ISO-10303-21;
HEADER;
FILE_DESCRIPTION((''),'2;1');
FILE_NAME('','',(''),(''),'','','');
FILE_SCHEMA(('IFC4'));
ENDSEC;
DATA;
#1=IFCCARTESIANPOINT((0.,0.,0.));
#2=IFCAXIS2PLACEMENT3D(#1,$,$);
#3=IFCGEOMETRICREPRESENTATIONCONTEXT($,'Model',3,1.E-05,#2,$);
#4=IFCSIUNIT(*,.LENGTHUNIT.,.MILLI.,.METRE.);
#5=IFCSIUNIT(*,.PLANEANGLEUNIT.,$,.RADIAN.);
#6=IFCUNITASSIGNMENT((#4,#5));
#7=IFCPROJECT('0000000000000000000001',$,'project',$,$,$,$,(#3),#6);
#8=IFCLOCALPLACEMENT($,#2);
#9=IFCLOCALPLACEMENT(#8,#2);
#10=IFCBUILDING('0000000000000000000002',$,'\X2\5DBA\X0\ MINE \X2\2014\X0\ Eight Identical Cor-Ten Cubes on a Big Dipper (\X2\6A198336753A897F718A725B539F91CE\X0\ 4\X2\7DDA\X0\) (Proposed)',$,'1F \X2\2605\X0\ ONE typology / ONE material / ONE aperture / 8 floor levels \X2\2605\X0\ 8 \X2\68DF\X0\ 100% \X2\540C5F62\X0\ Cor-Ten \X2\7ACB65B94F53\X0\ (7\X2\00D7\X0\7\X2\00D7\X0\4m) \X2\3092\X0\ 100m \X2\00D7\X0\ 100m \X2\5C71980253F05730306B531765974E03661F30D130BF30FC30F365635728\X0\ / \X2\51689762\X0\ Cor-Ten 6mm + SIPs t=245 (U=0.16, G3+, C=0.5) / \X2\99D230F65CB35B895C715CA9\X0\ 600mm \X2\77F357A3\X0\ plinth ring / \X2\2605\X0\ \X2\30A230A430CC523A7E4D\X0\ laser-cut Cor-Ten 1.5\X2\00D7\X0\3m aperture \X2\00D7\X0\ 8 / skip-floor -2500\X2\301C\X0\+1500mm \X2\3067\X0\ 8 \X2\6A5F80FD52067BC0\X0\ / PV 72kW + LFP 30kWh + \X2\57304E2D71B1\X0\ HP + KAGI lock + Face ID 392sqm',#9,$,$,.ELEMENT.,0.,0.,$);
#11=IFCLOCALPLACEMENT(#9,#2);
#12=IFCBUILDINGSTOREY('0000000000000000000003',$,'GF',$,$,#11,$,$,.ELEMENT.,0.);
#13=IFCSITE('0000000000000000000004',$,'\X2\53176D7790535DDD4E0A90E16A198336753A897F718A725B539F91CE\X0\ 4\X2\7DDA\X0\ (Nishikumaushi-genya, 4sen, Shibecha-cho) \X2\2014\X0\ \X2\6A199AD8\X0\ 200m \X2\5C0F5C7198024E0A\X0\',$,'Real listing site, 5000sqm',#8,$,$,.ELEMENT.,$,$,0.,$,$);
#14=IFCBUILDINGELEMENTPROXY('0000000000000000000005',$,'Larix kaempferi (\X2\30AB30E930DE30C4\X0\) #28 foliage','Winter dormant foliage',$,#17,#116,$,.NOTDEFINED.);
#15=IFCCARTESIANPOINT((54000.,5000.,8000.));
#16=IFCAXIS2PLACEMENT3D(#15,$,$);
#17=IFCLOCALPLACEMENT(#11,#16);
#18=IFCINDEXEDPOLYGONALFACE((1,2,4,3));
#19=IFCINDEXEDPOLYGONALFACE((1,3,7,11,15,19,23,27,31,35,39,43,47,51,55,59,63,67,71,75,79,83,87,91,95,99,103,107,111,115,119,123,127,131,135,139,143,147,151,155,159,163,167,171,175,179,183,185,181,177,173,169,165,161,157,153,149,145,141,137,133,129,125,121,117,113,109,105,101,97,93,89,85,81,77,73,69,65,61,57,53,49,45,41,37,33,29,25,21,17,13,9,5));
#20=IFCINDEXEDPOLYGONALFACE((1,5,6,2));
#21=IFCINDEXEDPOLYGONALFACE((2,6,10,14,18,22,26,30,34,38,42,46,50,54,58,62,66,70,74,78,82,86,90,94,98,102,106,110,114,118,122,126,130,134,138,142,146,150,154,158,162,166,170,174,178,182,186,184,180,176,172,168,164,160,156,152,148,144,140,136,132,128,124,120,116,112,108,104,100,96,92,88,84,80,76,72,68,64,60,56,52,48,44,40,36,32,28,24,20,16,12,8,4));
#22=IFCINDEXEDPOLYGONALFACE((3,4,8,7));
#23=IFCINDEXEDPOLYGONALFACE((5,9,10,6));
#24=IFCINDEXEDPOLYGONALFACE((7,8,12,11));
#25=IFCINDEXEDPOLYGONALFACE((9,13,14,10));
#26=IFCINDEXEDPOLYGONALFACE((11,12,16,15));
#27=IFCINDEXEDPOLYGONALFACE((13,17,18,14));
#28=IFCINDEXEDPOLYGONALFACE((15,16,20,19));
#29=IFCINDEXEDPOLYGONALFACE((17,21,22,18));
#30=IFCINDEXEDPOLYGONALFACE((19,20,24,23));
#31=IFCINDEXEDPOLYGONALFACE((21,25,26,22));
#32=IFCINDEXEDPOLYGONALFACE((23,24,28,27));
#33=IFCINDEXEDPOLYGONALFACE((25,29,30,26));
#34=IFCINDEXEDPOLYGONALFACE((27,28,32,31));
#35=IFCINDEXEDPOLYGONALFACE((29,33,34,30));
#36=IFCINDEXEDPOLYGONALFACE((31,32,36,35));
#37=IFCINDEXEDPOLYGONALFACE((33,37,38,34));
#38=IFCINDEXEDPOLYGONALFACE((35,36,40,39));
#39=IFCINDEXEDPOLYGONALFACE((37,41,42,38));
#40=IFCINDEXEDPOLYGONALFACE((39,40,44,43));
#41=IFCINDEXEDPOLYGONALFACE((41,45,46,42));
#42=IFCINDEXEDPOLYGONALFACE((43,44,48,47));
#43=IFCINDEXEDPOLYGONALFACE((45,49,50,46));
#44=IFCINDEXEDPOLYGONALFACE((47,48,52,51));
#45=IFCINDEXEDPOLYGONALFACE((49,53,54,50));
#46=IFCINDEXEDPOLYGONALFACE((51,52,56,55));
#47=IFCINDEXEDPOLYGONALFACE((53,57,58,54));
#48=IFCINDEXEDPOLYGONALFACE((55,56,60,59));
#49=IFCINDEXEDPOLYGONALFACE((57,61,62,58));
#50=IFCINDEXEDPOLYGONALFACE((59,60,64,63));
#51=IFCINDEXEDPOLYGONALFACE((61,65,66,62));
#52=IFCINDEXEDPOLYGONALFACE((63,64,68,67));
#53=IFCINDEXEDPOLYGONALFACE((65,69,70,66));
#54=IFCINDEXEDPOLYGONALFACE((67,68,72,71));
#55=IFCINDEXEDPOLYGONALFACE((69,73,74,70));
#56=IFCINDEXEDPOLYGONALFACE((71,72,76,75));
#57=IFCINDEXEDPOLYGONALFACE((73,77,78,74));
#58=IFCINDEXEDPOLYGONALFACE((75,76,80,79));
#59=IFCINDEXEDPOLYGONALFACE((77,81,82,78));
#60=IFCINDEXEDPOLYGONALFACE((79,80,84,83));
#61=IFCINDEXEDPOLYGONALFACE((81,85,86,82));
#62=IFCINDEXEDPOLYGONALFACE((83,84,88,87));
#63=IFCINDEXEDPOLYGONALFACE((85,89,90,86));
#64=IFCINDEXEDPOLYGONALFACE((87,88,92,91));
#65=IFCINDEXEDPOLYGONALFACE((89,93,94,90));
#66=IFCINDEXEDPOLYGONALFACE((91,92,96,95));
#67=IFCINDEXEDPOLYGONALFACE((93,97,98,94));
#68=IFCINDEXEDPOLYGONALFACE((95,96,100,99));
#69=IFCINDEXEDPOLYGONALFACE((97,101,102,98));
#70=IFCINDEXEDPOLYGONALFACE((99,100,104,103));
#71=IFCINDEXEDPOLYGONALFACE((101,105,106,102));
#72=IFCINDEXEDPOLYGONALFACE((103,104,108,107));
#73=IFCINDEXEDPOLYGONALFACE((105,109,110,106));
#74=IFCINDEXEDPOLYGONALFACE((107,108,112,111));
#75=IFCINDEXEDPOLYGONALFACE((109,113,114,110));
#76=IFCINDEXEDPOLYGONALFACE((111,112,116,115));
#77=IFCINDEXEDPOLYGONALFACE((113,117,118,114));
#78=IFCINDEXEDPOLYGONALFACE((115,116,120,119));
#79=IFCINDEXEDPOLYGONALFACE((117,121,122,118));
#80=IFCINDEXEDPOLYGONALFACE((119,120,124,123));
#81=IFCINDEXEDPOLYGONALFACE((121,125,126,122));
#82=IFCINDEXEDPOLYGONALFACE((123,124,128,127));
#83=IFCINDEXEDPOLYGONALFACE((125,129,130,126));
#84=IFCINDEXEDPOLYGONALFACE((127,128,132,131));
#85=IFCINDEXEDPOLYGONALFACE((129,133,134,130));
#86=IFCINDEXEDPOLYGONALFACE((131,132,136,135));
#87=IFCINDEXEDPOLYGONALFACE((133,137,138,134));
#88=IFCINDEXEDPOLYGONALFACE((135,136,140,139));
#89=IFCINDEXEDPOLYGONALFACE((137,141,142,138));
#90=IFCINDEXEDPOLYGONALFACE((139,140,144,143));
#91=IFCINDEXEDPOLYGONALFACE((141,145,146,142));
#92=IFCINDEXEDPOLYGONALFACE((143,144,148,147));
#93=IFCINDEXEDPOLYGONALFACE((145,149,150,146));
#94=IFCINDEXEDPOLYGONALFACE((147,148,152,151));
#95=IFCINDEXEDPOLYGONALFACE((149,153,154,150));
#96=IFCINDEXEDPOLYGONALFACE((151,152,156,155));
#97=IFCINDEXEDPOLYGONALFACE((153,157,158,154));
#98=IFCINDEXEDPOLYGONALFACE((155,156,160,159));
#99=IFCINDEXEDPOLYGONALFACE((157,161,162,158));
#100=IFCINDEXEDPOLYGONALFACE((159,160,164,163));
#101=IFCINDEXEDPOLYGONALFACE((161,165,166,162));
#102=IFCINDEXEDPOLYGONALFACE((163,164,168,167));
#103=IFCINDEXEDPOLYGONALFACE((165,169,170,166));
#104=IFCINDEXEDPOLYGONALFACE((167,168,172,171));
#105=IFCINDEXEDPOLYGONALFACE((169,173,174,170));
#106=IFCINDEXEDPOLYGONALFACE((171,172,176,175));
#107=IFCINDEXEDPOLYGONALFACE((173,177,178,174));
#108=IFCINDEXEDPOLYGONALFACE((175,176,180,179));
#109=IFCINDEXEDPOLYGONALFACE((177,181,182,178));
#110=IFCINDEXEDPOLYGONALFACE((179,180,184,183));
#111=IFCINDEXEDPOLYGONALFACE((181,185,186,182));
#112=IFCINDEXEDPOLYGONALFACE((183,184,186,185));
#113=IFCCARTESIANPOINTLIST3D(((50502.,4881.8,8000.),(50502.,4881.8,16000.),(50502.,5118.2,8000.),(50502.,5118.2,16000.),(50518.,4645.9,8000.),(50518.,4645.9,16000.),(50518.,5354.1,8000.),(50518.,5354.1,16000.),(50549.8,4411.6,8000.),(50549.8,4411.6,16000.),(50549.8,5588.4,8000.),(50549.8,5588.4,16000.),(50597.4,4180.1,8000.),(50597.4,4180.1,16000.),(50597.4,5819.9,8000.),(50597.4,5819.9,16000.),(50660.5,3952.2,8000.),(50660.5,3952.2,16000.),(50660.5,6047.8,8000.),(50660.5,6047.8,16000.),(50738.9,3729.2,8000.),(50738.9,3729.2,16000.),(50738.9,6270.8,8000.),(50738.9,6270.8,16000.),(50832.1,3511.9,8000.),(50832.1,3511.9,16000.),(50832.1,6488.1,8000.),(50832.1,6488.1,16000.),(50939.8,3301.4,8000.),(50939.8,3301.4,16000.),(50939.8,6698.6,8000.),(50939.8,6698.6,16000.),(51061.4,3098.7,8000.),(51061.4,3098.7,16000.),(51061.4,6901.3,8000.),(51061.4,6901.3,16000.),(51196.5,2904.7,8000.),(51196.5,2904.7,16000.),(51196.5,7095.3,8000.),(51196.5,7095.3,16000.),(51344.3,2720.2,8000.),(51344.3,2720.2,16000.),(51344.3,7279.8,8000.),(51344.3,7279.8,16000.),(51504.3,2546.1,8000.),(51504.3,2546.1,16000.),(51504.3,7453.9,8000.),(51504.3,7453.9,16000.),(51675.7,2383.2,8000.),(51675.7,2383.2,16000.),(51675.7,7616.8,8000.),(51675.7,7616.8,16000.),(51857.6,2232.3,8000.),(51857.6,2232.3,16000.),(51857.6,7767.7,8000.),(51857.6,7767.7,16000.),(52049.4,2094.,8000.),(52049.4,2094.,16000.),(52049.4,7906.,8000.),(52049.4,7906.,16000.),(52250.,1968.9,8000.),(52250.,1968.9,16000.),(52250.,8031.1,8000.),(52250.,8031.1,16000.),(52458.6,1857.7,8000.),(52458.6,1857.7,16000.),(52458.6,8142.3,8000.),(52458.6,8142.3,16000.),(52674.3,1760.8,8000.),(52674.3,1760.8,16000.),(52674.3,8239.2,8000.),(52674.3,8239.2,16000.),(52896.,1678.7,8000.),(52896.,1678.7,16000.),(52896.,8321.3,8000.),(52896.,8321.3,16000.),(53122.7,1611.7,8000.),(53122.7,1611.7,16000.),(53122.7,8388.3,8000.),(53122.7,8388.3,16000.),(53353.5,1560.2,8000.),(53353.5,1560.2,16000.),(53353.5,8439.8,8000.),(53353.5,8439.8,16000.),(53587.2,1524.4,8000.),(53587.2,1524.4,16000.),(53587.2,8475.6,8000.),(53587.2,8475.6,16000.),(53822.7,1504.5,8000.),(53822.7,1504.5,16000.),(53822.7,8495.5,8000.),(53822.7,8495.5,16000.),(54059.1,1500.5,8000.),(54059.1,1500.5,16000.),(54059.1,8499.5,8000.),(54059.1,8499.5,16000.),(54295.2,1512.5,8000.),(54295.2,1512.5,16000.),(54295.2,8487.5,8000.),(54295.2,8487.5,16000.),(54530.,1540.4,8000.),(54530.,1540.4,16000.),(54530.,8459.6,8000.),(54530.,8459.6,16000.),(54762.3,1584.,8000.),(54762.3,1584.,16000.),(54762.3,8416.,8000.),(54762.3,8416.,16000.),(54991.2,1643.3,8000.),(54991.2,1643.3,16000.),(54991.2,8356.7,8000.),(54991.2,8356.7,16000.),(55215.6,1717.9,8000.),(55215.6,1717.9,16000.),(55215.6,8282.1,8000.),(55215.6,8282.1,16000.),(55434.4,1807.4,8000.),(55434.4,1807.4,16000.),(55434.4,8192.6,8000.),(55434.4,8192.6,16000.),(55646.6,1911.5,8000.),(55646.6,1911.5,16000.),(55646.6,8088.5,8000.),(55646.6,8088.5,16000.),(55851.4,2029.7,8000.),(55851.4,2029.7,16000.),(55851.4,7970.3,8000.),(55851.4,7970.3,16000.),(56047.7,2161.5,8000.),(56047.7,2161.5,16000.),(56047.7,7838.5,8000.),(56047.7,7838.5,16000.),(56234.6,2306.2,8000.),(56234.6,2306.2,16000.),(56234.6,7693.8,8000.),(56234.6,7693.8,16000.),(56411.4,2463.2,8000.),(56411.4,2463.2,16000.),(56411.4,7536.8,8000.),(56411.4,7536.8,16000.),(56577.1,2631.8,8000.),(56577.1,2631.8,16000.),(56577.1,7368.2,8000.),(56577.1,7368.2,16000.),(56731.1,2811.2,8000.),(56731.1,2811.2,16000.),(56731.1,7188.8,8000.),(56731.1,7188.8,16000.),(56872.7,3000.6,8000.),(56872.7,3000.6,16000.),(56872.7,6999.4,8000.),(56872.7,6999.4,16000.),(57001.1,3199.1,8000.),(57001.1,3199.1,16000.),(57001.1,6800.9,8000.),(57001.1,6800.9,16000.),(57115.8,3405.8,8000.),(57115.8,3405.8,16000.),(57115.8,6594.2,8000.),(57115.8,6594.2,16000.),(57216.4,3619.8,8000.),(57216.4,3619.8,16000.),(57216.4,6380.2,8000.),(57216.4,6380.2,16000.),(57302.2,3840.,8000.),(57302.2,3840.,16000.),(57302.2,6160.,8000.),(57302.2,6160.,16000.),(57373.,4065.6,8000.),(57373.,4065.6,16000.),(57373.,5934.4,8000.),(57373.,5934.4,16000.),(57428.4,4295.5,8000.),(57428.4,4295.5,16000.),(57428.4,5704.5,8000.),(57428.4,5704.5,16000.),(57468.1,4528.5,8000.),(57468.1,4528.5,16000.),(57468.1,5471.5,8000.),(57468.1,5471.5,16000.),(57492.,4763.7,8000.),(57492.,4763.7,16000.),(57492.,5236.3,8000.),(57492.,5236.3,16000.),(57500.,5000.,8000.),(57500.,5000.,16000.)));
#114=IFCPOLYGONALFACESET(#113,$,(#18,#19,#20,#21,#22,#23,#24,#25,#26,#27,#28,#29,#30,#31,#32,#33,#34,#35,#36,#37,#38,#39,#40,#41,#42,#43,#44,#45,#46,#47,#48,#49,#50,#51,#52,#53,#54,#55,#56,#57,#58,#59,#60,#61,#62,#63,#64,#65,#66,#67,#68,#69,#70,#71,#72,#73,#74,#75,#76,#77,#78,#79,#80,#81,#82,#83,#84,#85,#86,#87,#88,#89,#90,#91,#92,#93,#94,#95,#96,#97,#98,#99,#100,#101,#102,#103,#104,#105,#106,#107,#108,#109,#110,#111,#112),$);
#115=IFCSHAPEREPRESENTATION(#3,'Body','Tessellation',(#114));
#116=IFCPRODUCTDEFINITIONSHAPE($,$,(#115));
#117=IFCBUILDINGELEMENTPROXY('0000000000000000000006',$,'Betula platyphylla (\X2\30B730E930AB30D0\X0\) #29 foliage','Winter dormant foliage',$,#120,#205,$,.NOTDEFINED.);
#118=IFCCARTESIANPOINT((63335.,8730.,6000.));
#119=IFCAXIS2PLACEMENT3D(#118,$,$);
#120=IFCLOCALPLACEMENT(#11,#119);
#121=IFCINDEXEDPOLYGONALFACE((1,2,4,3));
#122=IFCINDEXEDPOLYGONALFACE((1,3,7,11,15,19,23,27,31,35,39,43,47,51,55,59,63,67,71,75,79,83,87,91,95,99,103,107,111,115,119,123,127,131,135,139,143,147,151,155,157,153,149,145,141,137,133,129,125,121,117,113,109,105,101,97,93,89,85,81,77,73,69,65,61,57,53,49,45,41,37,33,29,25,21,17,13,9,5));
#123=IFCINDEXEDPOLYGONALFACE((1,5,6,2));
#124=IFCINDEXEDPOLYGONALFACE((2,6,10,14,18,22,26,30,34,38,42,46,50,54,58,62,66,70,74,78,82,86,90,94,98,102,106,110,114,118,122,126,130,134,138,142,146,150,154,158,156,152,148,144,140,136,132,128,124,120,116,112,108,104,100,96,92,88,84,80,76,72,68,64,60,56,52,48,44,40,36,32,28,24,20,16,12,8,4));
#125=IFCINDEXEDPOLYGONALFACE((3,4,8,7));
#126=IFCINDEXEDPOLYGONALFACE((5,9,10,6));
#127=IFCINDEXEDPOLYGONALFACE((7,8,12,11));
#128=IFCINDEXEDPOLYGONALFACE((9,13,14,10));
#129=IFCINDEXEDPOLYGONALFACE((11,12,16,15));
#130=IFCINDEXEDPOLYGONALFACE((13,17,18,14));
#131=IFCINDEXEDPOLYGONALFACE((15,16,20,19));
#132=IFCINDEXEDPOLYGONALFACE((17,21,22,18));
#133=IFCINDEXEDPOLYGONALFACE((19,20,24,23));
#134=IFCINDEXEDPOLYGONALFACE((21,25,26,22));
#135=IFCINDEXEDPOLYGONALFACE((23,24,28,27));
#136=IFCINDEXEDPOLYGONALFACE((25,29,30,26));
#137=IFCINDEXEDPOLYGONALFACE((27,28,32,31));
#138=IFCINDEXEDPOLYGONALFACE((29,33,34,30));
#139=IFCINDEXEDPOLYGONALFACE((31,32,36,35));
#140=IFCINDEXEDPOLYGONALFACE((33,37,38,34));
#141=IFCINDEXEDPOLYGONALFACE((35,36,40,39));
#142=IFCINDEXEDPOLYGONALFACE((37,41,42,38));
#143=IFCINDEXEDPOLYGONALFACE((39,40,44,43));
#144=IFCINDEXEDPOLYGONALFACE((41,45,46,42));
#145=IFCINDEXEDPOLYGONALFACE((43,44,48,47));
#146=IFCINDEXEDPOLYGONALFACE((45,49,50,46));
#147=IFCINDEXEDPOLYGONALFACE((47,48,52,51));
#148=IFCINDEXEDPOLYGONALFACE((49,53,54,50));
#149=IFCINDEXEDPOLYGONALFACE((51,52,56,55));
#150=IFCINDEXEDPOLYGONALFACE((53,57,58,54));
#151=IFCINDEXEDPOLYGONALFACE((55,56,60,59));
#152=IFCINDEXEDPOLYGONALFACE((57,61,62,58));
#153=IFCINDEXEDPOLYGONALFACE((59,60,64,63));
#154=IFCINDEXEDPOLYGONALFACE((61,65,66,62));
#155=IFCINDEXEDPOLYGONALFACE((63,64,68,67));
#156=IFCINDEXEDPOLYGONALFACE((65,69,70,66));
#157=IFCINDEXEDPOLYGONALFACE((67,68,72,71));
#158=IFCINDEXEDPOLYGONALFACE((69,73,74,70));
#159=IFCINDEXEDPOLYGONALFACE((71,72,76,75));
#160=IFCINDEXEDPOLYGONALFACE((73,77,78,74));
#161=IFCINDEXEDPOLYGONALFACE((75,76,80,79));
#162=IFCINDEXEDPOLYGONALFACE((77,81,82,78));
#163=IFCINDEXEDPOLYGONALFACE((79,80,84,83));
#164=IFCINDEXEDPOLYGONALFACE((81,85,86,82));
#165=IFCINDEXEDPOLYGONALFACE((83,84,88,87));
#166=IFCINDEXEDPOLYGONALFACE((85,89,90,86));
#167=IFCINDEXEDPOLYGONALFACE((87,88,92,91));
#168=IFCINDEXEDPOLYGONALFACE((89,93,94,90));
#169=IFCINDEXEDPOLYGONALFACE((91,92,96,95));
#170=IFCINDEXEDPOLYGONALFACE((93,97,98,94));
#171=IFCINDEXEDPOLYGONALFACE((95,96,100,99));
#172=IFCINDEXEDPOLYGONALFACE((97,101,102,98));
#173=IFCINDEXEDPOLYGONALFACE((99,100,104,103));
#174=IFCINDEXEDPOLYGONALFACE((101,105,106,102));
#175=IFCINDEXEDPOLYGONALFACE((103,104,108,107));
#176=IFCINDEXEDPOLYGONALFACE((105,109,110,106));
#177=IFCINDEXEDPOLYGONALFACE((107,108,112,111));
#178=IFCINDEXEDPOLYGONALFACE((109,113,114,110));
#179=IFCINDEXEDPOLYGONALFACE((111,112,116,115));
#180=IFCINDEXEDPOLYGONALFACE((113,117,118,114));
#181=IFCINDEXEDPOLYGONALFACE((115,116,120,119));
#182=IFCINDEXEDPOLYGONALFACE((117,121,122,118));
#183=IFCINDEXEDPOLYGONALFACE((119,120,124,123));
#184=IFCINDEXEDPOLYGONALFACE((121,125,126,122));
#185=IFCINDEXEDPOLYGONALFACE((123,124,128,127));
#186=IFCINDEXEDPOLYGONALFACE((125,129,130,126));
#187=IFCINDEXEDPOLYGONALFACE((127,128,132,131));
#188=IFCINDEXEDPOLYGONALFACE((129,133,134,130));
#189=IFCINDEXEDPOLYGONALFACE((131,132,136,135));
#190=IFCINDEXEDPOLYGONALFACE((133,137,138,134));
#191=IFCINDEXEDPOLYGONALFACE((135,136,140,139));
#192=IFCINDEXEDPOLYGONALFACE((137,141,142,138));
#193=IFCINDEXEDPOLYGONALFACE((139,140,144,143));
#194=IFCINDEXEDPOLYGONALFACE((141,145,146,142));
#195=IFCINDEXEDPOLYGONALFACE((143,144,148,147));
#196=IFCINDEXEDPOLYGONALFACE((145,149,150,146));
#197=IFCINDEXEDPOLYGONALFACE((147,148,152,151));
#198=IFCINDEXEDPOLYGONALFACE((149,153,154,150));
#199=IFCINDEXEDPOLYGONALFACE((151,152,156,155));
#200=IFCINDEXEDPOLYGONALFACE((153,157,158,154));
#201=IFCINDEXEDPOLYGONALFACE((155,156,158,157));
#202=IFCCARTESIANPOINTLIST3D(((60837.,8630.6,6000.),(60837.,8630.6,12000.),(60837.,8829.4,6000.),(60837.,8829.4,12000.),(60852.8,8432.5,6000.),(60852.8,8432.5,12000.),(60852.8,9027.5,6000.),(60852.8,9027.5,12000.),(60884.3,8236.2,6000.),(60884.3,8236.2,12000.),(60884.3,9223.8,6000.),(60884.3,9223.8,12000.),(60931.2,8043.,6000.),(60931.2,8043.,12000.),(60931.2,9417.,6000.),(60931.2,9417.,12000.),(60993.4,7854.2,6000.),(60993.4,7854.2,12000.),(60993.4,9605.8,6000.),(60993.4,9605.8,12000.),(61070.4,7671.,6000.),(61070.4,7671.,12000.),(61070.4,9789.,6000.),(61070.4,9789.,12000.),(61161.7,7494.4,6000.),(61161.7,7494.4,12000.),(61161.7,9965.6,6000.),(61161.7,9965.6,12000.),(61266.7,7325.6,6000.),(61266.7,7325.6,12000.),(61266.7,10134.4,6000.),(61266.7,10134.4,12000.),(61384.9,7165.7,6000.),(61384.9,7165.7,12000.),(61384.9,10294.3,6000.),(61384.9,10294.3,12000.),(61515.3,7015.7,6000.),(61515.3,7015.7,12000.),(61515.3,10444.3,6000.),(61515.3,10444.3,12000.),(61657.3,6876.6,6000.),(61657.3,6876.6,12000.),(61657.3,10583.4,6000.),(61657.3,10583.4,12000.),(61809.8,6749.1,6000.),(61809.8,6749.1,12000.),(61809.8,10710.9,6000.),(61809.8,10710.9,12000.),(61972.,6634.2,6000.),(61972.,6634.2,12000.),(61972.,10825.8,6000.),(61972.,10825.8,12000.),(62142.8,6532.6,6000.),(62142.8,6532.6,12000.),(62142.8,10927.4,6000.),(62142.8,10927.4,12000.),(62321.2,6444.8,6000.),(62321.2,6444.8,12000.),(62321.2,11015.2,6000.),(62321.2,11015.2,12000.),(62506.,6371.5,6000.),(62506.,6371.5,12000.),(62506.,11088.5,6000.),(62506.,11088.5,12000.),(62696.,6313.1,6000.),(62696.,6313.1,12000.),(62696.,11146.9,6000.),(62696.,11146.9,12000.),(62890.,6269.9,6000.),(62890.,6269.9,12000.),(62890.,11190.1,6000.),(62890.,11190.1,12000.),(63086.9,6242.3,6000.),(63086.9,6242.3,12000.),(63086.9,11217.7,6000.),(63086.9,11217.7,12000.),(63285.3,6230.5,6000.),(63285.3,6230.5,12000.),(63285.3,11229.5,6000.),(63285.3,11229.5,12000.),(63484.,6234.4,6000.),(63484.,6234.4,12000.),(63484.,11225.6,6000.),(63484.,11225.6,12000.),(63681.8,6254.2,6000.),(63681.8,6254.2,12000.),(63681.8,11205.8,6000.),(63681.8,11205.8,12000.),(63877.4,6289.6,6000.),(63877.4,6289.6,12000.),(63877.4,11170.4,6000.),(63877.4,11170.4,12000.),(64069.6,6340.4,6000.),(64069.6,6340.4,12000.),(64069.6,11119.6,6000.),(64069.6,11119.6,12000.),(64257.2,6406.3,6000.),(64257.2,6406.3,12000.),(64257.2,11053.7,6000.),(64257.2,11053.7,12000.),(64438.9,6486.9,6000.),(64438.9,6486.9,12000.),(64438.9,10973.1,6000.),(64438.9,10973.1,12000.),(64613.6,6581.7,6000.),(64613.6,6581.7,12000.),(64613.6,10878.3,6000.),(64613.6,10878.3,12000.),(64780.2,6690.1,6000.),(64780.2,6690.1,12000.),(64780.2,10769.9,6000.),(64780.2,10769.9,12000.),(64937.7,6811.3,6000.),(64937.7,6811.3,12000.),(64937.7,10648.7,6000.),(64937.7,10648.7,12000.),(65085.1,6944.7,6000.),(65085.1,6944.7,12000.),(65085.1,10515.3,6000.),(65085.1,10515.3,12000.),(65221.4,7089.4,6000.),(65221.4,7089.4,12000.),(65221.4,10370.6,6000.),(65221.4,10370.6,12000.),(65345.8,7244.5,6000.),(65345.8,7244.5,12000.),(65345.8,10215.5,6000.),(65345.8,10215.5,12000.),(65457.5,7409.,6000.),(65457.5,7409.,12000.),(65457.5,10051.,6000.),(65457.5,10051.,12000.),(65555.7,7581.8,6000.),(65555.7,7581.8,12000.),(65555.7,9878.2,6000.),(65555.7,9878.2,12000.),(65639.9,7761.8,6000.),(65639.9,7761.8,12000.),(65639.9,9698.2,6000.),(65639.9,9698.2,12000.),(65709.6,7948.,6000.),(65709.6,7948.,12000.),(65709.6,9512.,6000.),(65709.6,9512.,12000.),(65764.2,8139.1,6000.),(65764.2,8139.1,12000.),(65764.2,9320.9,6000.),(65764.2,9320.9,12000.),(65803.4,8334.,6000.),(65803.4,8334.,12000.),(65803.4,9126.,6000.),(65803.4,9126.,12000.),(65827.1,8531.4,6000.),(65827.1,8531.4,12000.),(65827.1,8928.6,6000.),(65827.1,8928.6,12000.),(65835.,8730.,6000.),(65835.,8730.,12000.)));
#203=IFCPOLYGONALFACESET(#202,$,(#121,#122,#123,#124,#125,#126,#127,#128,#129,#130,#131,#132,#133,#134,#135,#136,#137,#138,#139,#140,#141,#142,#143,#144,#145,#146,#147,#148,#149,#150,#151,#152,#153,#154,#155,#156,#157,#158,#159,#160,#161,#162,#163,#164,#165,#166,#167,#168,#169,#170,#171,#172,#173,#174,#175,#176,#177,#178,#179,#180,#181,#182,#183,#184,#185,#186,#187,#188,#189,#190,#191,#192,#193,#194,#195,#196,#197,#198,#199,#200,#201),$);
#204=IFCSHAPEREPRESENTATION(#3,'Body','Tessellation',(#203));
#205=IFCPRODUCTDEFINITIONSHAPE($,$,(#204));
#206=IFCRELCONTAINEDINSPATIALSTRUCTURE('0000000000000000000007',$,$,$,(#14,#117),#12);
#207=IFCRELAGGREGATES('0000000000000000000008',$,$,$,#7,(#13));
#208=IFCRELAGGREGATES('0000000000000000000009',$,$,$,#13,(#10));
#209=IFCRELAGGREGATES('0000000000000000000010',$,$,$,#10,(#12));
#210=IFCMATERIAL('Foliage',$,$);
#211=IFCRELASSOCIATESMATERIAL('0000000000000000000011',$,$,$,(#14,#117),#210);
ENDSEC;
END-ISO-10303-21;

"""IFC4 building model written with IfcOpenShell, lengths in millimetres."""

from ifc_helpers import new_model, si_unit, frame, origin, origin_2d, place, context, project, spatial, circle, extrude, material, element, save


model = new_model("IFC4")

# Units and contexts
model_context = context("Model", 3, precision=1e-05, world=origin())
ifc_project = project(units=[si_unit("LENGTHUNIT", "METRE", prefix="MILLI"), si_unit("PLANEANGLEUNIT", "RADIAN")], contexts=[model_context])

# Site, building, storey
site_placement = place(None, origin())
site = spatial("IfcSite", under=ifc_project, at=site_placement, Name="北海道川上郡標茶町西熊牛原野 4線 (Nishikumaushi-genya, 4sen, Shibecha-cho) — 標高 200m 小山頂上", ObjectType="Real listing site, 5000sqm", CompositionType="ELEMENT", RefElevation=0.0)
building_placement = place(site_placement, origin())
building = spatial("IfcBuilding", under=site, at=building_placement, Name="嶺 MINE — Eight Identical Cor-Ten Cubes on a Big Dipper (標茶町西熊牛原野 4線) (Proposed)", ObjectType="1F ★ ONE typology / ONE material / ONE aperture / 8 floor levels ★ 8 棟 100% 同形 Cor-Ten 立方体 (7×7×4m) を 100m × 100m 山頂台地に北斗七星パターン散在 / 全面 Cor-Ten 6mm + SIPs t=245 (U=0.16, G3+, C=0.5) / 駒ヶ岳安山岩 600mm 石垣 plinth ring / ★ アイヌ刺繍 laser-cut Cor-Ten 1.5×3m aperture × 8 / skip-floor -2500〜+1500mm で 8 機能分節 / PV 72kW + LFP 30kWh + 地中熱 HP + KAGI lock + Face ID 392sqm", CompositionType="ELEMENT", ElevationOfRefHeight=0.0, ElevationOfTerrain=0.0)
storey_placement = place(building_placement, origin())
storey = spatial("IfcBuildingStorey", under=building, at=storey_placement, Name="GF", CompositionType="ELEMENT", Elevation=0.0)

# Building element proxies
ifc_material_1 = material(Name="Foliage")
proxy_1_placement = place(storey_placement, frame((54000.0, 5000.0, 8000.0)))
element("IfcBuildingElementProxy", 1, at=proxy_1_placement, inside=storey, material=ifc_material_1, Name="Larix kaempferi (カラマツ) #28 foliage", Description="Winter dormant foliage", PredefinedType="NOTDEFINED", context=model_context, shape_type="SweptSolid", body=[
    extrude(circle(Radius=3500.0, at=origin_2d()), frame((54000.0, 5000.0, 8000.0)), (0.0, 0.0, 1.0), 8000.0),
])
proxy_2_placement = place(storey_placement, frame((63335.0, 8730.0, 6000.0)))
element("IfcBuildingElementProxy", 2, at=proxy_2_placement, inside=storey, material=ifc_material_1, Name="Betula platyphylla (シラカバ) #29 foliage", Description="Winter dormant foliage", PredefinedType="NOTDEFINED", context=model_context, shape_type="SweptSolid", body=[
    extrude(circle(Radius=2500.0, at=origin_2d()), frame((63335.0, 8730.0, 6000.0)), (0.0, 0.0, 1.0), 6000.0),
])

save(model, "model.ifc")
